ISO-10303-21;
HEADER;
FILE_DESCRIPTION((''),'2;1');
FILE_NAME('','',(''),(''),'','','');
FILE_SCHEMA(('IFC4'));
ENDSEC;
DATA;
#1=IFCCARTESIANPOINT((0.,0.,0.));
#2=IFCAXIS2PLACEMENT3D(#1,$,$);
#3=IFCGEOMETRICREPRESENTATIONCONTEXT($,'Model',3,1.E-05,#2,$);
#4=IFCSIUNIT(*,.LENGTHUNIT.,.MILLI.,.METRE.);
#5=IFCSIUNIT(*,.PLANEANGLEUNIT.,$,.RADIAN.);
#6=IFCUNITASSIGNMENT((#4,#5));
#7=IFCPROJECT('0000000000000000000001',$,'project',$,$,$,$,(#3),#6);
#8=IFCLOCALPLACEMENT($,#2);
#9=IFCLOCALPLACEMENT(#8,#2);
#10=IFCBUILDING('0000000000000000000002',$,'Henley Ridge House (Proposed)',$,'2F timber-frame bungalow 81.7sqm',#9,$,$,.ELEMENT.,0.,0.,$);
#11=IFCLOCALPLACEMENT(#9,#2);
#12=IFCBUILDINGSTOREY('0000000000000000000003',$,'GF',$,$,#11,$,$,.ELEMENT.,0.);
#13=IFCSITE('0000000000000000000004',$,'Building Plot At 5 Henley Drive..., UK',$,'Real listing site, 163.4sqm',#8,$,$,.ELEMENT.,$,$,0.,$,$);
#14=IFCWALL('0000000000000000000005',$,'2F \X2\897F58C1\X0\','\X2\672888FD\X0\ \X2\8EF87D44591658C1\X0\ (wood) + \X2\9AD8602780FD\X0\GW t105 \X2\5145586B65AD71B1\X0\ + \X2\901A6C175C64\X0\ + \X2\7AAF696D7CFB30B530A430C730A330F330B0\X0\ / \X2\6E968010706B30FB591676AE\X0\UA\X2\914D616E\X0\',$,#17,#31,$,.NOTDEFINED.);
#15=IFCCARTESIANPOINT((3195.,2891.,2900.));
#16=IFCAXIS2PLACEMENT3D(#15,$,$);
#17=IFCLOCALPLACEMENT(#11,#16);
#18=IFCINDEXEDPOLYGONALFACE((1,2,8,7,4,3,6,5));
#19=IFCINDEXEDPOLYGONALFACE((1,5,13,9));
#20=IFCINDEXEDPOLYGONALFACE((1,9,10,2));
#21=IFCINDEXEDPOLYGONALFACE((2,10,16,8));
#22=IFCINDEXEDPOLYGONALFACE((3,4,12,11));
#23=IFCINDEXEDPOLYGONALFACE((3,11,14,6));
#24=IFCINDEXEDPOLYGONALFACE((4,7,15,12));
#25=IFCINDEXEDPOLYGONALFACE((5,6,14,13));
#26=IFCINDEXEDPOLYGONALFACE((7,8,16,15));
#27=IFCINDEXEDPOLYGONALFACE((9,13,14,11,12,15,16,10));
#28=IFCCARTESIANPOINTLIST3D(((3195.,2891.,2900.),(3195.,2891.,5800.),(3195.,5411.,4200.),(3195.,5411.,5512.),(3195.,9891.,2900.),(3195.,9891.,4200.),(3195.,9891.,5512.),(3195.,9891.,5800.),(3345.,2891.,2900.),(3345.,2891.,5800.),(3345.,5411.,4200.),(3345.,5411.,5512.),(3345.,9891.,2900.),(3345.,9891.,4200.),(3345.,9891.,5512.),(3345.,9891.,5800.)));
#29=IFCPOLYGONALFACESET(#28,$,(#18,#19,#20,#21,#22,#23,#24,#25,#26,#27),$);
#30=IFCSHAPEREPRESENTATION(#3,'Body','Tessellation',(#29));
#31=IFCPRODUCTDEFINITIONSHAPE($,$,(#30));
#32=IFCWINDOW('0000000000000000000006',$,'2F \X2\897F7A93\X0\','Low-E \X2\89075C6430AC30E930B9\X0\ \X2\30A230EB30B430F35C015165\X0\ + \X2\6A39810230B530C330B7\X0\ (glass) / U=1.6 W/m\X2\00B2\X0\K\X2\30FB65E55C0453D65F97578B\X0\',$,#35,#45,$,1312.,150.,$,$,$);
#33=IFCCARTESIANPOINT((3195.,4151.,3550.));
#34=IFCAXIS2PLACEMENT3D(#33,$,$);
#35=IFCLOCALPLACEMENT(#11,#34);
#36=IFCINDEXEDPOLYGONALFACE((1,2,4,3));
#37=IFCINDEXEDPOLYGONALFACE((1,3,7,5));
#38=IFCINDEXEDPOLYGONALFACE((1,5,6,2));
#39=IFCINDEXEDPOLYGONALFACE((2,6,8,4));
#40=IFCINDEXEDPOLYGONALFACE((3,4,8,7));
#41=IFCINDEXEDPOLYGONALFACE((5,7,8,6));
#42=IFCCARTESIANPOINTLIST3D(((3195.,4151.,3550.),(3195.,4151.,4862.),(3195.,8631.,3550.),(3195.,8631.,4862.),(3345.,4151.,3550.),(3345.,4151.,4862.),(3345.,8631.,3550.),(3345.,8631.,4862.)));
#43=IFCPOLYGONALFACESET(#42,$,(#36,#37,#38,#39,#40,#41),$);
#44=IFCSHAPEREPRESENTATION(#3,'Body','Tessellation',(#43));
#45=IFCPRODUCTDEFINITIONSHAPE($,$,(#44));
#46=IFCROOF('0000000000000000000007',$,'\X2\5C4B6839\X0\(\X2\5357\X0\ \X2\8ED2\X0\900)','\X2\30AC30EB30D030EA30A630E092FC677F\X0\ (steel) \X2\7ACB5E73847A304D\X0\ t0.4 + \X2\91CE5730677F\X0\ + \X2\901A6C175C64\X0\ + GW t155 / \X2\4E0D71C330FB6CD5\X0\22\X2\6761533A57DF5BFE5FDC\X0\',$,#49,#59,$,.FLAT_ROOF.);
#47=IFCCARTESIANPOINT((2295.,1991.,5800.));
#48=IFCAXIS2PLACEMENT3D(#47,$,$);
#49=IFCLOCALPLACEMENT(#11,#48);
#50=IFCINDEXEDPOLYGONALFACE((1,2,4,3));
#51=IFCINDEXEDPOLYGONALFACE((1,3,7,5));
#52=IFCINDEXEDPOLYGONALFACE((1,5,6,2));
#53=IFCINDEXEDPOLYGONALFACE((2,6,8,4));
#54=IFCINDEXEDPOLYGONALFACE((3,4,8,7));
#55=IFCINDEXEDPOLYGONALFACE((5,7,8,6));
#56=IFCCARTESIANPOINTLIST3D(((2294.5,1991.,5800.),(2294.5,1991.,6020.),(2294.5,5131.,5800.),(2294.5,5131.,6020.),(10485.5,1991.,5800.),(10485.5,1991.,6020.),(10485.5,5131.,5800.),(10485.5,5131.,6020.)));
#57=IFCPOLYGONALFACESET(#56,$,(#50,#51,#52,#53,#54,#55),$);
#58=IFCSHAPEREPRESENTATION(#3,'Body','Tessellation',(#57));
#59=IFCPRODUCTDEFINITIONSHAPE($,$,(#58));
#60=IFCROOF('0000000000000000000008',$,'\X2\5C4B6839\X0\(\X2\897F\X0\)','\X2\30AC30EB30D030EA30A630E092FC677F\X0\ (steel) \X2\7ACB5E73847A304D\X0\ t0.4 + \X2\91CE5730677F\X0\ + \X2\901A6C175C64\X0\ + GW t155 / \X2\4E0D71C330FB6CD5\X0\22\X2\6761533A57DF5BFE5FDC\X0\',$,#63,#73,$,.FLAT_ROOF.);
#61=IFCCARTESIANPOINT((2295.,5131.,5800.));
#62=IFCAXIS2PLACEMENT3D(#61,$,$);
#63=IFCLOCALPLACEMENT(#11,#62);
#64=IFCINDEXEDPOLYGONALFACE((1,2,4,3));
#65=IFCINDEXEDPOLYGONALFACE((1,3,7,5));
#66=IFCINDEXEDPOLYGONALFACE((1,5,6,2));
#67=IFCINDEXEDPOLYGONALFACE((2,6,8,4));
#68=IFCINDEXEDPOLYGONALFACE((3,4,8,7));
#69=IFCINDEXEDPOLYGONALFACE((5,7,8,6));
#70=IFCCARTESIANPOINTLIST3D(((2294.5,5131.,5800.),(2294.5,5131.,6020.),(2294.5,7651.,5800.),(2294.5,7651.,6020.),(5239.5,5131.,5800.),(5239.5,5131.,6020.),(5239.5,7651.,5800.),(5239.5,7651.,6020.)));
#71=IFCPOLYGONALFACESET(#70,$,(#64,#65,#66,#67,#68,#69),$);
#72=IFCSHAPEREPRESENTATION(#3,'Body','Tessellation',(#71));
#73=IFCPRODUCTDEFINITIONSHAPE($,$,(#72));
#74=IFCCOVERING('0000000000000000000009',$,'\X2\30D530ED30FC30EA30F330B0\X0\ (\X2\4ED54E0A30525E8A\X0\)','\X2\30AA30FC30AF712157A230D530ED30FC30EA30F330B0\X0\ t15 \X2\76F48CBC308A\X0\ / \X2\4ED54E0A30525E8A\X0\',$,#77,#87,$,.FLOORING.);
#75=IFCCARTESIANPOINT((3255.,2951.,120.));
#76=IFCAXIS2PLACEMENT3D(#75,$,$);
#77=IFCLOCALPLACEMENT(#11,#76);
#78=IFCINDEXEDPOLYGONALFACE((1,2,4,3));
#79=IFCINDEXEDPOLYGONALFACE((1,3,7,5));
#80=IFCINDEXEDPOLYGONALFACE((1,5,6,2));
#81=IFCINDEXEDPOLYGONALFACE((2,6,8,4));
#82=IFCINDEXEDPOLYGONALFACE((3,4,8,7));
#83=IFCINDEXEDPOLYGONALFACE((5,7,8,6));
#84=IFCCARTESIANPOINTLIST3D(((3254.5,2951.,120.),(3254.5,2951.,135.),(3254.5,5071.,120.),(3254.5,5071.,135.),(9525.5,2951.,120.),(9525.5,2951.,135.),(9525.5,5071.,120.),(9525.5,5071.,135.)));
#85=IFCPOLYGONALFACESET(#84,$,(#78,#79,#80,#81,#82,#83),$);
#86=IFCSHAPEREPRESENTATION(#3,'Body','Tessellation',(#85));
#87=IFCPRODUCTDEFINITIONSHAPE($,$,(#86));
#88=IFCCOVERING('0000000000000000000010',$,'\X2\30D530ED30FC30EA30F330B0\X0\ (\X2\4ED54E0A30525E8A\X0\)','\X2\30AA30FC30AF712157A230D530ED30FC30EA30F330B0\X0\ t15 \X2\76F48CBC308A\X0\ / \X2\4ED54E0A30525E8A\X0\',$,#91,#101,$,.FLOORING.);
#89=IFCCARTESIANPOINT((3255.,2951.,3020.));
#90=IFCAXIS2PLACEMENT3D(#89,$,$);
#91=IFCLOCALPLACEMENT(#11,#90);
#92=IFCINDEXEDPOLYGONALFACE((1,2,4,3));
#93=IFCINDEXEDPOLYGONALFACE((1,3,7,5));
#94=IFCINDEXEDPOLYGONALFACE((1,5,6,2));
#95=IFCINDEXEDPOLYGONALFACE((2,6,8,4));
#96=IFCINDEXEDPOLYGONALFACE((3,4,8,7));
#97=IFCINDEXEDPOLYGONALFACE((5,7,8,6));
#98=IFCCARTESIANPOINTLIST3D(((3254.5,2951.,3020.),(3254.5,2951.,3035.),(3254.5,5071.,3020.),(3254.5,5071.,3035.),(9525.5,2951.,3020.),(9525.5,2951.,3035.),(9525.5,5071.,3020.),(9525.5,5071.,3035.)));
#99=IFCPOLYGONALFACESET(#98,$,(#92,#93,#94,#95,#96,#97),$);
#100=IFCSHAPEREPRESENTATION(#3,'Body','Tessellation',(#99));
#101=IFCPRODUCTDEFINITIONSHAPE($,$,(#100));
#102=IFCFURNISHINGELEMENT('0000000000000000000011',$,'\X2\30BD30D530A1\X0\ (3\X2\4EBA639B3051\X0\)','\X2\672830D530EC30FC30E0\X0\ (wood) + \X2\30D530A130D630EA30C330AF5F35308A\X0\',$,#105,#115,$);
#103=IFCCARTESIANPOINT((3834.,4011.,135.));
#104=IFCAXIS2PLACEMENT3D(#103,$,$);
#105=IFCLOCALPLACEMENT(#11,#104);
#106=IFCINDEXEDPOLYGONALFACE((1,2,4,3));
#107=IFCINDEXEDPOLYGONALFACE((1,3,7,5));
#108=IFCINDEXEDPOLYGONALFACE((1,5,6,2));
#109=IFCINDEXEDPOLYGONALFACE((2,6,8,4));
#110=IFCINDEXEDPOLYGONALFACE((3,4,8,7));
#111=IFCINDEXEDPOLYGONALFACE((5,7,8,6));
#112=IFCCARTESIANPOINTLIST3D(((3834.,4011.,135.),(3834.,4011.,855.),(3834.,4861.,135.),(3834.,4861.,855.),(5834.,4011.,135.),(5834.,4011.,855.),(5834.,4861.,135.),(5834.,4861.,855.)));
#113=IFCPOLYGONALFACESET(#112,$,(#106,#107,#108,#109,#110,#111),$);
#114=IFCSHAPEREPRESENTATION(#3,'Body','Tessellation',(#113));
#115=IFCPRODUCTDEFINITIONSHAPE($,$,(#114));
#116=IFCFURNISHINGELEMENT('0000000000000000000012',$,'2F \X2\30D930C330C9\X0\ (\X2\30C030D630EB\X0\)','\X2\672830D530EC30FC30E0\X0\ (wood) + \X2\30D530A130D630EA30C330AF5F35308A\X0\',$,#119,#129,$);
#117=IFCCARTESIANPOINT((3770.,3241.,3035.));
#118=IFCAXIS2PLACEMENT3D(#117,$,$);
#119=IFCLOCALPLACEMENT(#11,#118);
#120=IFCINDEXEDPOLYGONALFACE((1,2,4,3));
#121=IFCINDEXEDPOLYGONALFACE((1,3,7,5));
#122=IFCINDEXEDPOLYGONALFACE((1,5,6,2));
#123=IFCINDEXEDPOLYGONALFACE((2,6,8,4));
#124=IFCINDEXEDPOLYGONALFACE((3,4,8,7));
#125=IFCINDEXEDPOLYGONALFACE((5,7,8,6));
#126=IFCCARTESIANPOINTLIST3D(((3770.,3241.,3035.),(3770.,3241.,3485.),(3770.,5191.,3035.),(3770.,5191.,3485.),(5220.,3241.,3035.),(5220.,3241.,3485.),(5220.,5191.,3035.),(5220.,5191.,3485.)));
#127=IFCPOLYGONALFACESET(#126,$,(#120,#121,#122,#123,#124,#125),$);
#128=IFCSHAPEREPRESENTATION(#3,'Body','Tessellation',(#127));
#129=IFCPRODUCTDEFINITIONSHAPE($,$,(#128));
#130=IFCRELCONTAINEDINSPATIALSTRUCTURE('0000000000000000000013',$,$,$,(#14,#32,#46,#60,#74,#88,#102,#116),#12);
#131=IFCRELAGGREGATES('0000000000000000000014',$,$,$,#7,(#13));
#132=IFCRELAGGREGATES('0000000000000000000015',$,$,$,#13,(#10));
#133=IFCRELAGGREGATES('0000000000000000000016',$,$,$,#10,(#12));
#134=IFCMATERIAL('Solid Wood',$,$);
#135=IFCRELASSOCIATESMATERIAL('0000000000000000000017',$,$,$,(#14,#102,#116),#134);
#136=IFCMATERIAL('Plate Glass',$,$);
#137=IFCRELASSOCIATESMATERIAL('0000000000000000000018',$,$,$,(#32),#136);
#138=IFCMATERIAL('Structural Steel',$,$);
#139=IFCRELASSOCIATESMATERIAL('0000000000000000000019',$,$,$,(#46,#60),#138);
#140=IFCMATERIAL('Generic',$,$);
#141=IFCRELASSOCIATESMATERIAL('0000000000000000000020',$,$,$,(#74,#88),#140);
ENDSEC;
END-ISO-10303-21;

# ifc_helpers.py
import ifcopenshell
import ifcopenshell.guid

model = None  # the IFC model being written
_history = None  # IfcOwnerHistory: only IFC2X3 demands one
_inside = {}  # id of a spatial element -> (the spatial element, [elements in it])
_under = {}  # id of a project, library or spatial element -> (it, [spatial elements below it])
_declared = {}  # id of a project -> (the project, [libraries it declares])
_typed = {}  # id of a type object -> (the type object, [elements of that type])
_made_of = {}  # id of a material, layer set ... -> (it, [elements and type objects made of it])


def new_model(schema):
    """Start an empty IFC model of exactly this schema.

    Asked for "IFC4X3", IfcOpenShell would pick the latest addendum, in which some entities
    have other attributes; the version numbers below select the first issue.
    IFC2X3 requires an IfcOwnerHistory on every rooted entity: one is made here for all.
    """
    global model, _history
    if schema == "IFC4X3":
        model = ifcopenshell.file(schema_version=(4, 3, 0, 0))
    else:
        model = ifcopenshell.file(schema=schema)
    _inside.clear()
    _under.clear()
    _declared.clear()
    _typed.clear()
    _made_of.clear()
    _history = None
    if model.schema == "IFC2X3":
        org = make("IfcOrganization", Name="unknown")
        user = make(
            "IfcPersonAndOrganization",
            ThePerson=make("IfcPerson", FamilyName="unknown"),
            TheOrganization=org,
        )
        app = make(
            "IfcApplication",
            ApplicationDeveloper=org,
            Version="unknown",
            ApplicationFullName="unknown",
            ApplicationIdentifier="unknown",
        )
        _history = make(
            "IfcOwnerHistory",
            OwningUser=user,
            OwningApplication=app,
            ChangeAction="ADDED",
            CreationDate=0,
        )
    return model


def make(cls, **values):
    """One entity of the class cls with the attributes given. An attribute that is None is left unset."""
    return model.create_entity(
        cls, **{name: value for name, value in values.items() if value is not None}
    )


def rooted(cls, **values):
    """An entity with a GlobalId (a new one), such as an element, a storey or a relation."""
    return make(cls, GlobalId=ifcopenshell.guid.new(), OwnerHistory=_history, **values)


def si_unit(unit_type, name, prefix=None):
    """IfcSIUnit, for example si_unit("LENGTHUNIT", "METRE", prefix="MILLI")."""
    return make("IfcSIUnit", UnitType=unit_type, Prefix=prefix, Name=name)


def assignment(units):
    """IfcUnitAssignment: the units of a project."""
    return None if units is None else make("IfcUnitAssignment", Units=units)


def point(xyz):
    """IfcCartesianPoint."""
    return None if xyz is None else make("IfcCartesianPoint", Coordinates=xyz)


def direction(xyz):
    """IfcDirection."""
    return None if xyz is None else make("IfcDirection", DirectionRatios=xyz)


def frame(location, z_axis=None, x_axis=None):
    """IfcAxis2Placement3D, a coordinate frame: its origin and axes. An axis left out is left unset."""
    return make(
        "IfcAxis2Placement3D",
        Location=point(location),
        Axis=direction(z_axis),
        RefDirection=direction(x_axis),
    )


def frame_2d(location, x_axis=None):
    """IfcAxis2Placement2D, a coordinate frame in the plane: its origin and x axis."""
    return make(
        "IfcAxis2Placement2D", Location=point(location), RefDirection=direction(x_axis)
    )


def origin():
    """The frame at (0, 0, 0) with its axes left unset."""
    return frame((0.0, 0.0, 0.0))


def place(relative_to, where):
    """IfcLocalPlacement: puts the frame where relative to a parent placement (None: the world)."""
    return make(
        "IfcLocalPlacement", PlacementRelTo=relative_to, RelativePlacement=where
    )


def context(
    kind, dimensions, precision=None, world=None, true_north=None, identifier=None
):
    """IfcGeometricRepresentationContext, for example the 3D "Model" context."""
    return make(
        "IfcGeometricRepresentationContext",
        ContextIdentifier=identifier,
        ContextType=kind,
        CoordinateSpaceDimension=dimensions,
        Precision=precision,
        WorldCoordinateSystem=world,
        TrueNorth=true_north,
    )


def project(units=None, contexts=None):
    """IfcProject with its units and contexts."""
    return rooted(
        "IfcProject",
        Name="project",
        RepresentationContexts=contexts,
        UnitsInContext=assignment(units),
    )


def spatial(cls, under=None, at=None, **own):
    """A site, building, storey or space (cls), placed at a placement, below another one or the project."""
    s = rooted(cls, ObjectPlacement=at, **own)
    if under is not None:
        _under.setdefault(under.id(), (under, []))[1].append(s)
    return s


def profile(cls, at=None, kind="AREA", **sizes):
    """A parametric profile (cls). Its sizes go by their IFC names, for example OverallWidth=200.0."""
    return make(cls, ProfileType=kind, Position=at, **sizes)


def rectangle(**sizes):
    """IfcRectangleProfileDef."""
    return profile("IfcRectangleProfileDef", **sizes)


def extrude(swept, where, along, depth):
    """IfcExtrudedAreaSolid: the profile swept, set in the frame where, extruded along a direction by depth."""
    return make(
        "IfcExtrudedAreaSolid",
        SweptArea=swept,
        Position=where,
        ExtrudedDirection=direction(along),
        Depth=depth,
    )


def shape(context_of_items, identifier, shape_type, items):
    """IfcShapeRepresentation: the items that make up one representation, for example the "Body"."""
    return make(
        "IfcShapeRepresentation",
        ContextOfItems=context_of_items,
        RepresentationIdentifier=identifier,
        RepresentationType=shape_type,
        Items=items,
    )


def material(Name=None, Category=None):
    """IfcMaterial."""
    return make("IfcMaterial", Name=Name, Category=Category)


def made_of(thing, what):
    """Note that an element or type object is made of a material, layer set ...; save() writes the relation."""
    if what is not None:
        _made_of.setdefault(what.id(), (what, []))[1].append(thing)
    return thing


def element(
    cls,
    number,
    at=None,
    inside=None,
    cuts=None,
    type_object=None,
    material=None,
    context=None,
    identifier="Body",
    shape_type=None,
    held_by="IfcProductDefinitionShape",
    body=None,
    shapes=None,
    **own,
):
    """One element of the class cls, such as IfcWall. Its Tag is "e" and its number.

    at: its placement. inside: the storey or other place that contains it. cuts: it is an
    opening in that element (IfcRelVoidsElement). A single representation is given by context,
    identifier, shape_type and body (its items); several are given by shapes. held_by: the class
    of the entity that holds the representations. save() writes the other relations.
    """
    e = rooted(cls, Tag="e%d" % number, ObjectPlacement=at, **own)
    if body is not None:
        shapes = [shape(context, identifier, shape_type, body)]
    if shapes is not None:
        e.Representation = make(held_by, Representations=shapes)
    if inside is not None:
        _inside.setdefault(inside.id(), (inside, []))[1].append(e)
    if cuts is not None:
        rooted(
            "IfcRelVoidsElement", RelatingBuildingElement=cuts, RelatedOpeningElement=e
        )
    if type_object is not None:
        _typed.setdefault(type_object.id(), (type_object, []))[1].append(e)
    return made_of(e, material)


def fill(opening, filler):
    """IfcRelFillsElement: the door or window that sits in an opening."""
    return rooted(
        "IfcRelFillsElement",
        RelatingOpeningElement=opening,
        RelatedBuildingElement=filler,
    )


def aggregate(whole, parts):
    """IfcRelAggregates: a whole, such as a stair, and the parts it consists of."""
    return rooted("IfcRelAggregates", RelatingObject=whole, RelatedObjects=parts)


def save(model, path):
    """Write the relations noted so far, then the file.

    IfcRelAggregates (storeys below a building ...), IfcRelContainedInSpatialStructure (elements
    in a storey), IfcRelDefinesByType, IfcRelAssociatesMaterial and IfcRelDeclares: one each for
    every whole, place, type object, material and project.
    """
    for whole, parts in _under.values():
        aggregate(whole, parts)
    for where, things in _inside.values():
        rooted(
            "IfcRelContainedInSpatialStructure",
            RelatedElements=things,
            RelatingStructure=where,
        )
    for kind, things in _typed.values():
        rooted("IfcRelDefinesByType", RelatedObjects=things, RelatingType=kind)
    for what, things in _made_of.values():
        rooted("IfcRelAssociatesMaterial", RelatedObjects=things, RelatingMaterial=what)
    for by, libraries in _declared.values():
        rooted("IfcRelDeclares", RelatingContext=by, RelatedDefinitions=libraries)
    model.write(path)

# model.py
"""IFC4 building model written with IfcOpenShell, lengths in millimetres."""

from ifc_helpers import new_model, si_unit, frame, frame_2d, origin, place, context, project, spatial, rectangle, extrude, material, element, fill, save


model = new_model("IFC4")

# Units and contexts
model_context = context("Model", 3, precision=1e-05, world=origin())
ifc_project = project(units=[si_unit("LENGTHUNIT", "METRE", prefix="MILLI"), si_unit("PLANEANGLEUNIT", "RADIAN")], contexts=[model_context])

# Site, building, storey
site_placement = place(None, origin())
site = spatial("IfcSite", under=ifc_project, at=site_placement, Name="Building Plot At 5 Henley Drive..., UK", ObjectType="Real listing site, 163.4sqm", CompositionType="ELEMENT", RefElevation=0.0)
building_placement = place(site_placement, origin())
building = spatial("IfcBuilding", under=site, at=building_placement, Name="Henley Ridge House (Proposed)", ObjectType="2F timber-frame bungalow 81.7sqm", CompositionType="ELEMENT", ElevationOfRefHeight=0.0, ElevationOfTerrain=0.0)
storey_placement = place(building_placement, origin())
storey = spatial("IfcBuildingStorey", under=building, at=storey_placement, Name="GF", CompositionType="ELEMENT", Elevation=0.0)

# Shared definitions
ifc_material_1 = material(Name="Solid Wood")

# Shared definitions
ifc_material_2 = material(Name="Plate Glass")

# Wall, opening, window
wall_1_placement = place(storey_placement, frame((3195.0, 2891.0, 2900.0)))
wall_1 = element("IfcWall", 1, at=wall_1_placement, inside=storey, material=ifc_material_1, Name="2F 西壁", Description="木製 軸組外壁 (wood) + 高性能GW t105 充填断熱 + 通気層 + 窯業系サイディング / 準耐火・外皮UA配慮", PredefinedType="NOTDEFINED", context=model_context, shape_type="SweptSolid", body=[
    extrude(rectangle(XDim=150.0, YDim=7000.0, at=frame_2d((75.0, 3500.0))), frame((3195.0, 2891.0, 2900.0)), (0.0, 0.0, 1.0), 2900.0),
])
opening_1_placement = place(storey_placement, frame((3195.0, 4151.0, 3550.0)))
opening_1 = element("IfcOpeningElement", 2, at=opening_1_placement, cuts=wall_1, PredefinedType="NOTDEFINED", context=model_context, shape_type="SweptSolid", body=[
    extrude(rectangle(XDim=150.0, YDim=4480.0, at=frame_2d((75.0, 2240.0))), frame((3195.0, 4151.0, 3550.0)), (0.0, 0.0, 1.0), 1312.0),
])
window_1_placement = place(storey_placement, frame((3195.0, 4151.0, 3550.0)))
window_1 = element("IfcWindow", 3, at=window_1_placement, inside=storey, material=ifc_material_2, Name="2F 西窓", Description="Low-E 複層ガラス アルゴン封入 + 樹脂サッシ (glass) / U=1.6 W/m²K・日射取得型", OverallHeight=1312.0, OverallWidth=150.0, context=model_context, shape_type="SweptSolid", body=[
    extrude(rectangle(XDim=150.0, YDim=4480.0, at=frame_2d((75.0, 2240.0))), frame((3195.0, 4151.0, 3550.0)), (0.0, 0.0, 1.0), 1312.0),
])
fill(opening_1, window_1)

# Roofs
ifc_material_3 = material(Name="Structural Steel")
roof_1_placement = place(storey_placement, frame((2295.0, 1991.0, 5800.0)))
element("IfcRoof", 4, at=roof_1_placement, inside=storey, material=ifc_material_3, Name="屋根(南 軒900)", Description="ガルバリウム鋼板 (steel) 立平葺き t0.4 + 野地板 + 通気層 + GW t155 / 不燃・法22条区域対応", PredefinedType="FLAT_ROOF", context=model_context, shape_type="SweptSolid", body=[
    extrude(rectangle(XDim=8191.0, YDim=3140.0, at=frame_2d((4095.0, 1570.0))), frame((2295.0, 1991.0, 5800.0)), (0.0, 0.0, 1.0), 220.0),
])
roof_2_placement = place(storey_placement, frame((2295.0, 5131.0, 5800.0)))
element("IfcRoof", 5, at=roof_2_placement, inside=storey, material=ifc_material_3, Name="屋根(西)", Description="ガルバリウム鋼板 (steel) 立平葺き t0.4 + 野地板 + 通気層 + GW t155 / 不燃・法22条区域対応", PredefinedType="FLAT_ROOF", context=model_context, shape_type="SweptSolid", body=[
    extrude(rectangle(XDim=2945.0, YDim=2520.0, at=frame_2d((1472.0, 1260.0))), frame((2295.0, 5131.0, 5800.0)), (0.0, 0.0, 1.0), 220.0),
])

# Coverings
ifc_material_4 = material(Name="Generic")
covering_1_placement = place(storey_placement, frame((3255.0, 2951.0, 120.0)))
element("IfcCovering", 6, at=covering_1_placement, inside=storey, material=ifc_material_4, Name="フローリング (仕上げ床)", Description="オーク無垢フローリング t15 直貼り / 仕上げ床", PredefinedType="FLOORING", context=model_context, shape_type="SweptSolid", body=[
    extrude(rectangle(XDim=6271.0, YDim=2120.0, at=frame_2d((3135.0, 1060.0))), frame((3255.0, 2951.0, 120.0)), (0.0, 0.0, 1.0), 15.0),
])
covering_2_placement = place(storey_placement, frame((3255.0, 2951.0, 3020.0)))
element("IfcCovering", 7, at=covering_2_placement, inside=storey, material=ifc_material_4, Name="フローリング (仕上げ床)", Description="オーク無垢フローリング t15 直貼り / 仕上げ床", PredefinedType="FLOORING", context=model_context, shape_type="SweptSolid", body=[
    extrude(rectangle(XDim=6271.0, YDim=2120.0, at=frame_2d((3135.0, 1060.0))), frame((3255.0, 2951.0, 3020.0)), (0.0, 0.0, 1.0), 15.0),
])

# Furnishing elements
furnishing_1_placement = place(storey_placement, frame((3834.0, 4011.0, 135.0)))
element("IfcFurnishingElement", 8, at=furnishing_1_placement, inside=storey, material=ifc_material_1, Name="ソファ (3人掛け)", Description="木フレーム (wood) + ファブリック張り", context=model_context, shape_type="SweptSolid", body=[
    extrude(rectangle(XDim=2000.0, YDim=850.0, at=frame_2d((1000.0, 425.0))), frame((3834.0, 4011.0, 135.0)), (0.0, 0.0, 1.0), 720.0),
])
furnishing_2_placement = place(storey_placement, frame((3770.0, 3241.0, 3035.0)))
element("IfcFurnishingElement", 9, at=furnishing_2_placement, inside=storey, material=ifc_material_1, Name="2F ベッド (ダブル)", Description="木フレーム (wood) + ファブリック張り", context=model_context, shape_type="SweptSolid", body=[
    extrude(rectangle(XDim=1450.0, YDim=1950.0, at=frame_2d((725.0, 975.0))), frame((3770.0, 3241.0, 3035.0)), (0.0, 0.0, 1.0), 450.0),
])

save(model, "model.ifc")
